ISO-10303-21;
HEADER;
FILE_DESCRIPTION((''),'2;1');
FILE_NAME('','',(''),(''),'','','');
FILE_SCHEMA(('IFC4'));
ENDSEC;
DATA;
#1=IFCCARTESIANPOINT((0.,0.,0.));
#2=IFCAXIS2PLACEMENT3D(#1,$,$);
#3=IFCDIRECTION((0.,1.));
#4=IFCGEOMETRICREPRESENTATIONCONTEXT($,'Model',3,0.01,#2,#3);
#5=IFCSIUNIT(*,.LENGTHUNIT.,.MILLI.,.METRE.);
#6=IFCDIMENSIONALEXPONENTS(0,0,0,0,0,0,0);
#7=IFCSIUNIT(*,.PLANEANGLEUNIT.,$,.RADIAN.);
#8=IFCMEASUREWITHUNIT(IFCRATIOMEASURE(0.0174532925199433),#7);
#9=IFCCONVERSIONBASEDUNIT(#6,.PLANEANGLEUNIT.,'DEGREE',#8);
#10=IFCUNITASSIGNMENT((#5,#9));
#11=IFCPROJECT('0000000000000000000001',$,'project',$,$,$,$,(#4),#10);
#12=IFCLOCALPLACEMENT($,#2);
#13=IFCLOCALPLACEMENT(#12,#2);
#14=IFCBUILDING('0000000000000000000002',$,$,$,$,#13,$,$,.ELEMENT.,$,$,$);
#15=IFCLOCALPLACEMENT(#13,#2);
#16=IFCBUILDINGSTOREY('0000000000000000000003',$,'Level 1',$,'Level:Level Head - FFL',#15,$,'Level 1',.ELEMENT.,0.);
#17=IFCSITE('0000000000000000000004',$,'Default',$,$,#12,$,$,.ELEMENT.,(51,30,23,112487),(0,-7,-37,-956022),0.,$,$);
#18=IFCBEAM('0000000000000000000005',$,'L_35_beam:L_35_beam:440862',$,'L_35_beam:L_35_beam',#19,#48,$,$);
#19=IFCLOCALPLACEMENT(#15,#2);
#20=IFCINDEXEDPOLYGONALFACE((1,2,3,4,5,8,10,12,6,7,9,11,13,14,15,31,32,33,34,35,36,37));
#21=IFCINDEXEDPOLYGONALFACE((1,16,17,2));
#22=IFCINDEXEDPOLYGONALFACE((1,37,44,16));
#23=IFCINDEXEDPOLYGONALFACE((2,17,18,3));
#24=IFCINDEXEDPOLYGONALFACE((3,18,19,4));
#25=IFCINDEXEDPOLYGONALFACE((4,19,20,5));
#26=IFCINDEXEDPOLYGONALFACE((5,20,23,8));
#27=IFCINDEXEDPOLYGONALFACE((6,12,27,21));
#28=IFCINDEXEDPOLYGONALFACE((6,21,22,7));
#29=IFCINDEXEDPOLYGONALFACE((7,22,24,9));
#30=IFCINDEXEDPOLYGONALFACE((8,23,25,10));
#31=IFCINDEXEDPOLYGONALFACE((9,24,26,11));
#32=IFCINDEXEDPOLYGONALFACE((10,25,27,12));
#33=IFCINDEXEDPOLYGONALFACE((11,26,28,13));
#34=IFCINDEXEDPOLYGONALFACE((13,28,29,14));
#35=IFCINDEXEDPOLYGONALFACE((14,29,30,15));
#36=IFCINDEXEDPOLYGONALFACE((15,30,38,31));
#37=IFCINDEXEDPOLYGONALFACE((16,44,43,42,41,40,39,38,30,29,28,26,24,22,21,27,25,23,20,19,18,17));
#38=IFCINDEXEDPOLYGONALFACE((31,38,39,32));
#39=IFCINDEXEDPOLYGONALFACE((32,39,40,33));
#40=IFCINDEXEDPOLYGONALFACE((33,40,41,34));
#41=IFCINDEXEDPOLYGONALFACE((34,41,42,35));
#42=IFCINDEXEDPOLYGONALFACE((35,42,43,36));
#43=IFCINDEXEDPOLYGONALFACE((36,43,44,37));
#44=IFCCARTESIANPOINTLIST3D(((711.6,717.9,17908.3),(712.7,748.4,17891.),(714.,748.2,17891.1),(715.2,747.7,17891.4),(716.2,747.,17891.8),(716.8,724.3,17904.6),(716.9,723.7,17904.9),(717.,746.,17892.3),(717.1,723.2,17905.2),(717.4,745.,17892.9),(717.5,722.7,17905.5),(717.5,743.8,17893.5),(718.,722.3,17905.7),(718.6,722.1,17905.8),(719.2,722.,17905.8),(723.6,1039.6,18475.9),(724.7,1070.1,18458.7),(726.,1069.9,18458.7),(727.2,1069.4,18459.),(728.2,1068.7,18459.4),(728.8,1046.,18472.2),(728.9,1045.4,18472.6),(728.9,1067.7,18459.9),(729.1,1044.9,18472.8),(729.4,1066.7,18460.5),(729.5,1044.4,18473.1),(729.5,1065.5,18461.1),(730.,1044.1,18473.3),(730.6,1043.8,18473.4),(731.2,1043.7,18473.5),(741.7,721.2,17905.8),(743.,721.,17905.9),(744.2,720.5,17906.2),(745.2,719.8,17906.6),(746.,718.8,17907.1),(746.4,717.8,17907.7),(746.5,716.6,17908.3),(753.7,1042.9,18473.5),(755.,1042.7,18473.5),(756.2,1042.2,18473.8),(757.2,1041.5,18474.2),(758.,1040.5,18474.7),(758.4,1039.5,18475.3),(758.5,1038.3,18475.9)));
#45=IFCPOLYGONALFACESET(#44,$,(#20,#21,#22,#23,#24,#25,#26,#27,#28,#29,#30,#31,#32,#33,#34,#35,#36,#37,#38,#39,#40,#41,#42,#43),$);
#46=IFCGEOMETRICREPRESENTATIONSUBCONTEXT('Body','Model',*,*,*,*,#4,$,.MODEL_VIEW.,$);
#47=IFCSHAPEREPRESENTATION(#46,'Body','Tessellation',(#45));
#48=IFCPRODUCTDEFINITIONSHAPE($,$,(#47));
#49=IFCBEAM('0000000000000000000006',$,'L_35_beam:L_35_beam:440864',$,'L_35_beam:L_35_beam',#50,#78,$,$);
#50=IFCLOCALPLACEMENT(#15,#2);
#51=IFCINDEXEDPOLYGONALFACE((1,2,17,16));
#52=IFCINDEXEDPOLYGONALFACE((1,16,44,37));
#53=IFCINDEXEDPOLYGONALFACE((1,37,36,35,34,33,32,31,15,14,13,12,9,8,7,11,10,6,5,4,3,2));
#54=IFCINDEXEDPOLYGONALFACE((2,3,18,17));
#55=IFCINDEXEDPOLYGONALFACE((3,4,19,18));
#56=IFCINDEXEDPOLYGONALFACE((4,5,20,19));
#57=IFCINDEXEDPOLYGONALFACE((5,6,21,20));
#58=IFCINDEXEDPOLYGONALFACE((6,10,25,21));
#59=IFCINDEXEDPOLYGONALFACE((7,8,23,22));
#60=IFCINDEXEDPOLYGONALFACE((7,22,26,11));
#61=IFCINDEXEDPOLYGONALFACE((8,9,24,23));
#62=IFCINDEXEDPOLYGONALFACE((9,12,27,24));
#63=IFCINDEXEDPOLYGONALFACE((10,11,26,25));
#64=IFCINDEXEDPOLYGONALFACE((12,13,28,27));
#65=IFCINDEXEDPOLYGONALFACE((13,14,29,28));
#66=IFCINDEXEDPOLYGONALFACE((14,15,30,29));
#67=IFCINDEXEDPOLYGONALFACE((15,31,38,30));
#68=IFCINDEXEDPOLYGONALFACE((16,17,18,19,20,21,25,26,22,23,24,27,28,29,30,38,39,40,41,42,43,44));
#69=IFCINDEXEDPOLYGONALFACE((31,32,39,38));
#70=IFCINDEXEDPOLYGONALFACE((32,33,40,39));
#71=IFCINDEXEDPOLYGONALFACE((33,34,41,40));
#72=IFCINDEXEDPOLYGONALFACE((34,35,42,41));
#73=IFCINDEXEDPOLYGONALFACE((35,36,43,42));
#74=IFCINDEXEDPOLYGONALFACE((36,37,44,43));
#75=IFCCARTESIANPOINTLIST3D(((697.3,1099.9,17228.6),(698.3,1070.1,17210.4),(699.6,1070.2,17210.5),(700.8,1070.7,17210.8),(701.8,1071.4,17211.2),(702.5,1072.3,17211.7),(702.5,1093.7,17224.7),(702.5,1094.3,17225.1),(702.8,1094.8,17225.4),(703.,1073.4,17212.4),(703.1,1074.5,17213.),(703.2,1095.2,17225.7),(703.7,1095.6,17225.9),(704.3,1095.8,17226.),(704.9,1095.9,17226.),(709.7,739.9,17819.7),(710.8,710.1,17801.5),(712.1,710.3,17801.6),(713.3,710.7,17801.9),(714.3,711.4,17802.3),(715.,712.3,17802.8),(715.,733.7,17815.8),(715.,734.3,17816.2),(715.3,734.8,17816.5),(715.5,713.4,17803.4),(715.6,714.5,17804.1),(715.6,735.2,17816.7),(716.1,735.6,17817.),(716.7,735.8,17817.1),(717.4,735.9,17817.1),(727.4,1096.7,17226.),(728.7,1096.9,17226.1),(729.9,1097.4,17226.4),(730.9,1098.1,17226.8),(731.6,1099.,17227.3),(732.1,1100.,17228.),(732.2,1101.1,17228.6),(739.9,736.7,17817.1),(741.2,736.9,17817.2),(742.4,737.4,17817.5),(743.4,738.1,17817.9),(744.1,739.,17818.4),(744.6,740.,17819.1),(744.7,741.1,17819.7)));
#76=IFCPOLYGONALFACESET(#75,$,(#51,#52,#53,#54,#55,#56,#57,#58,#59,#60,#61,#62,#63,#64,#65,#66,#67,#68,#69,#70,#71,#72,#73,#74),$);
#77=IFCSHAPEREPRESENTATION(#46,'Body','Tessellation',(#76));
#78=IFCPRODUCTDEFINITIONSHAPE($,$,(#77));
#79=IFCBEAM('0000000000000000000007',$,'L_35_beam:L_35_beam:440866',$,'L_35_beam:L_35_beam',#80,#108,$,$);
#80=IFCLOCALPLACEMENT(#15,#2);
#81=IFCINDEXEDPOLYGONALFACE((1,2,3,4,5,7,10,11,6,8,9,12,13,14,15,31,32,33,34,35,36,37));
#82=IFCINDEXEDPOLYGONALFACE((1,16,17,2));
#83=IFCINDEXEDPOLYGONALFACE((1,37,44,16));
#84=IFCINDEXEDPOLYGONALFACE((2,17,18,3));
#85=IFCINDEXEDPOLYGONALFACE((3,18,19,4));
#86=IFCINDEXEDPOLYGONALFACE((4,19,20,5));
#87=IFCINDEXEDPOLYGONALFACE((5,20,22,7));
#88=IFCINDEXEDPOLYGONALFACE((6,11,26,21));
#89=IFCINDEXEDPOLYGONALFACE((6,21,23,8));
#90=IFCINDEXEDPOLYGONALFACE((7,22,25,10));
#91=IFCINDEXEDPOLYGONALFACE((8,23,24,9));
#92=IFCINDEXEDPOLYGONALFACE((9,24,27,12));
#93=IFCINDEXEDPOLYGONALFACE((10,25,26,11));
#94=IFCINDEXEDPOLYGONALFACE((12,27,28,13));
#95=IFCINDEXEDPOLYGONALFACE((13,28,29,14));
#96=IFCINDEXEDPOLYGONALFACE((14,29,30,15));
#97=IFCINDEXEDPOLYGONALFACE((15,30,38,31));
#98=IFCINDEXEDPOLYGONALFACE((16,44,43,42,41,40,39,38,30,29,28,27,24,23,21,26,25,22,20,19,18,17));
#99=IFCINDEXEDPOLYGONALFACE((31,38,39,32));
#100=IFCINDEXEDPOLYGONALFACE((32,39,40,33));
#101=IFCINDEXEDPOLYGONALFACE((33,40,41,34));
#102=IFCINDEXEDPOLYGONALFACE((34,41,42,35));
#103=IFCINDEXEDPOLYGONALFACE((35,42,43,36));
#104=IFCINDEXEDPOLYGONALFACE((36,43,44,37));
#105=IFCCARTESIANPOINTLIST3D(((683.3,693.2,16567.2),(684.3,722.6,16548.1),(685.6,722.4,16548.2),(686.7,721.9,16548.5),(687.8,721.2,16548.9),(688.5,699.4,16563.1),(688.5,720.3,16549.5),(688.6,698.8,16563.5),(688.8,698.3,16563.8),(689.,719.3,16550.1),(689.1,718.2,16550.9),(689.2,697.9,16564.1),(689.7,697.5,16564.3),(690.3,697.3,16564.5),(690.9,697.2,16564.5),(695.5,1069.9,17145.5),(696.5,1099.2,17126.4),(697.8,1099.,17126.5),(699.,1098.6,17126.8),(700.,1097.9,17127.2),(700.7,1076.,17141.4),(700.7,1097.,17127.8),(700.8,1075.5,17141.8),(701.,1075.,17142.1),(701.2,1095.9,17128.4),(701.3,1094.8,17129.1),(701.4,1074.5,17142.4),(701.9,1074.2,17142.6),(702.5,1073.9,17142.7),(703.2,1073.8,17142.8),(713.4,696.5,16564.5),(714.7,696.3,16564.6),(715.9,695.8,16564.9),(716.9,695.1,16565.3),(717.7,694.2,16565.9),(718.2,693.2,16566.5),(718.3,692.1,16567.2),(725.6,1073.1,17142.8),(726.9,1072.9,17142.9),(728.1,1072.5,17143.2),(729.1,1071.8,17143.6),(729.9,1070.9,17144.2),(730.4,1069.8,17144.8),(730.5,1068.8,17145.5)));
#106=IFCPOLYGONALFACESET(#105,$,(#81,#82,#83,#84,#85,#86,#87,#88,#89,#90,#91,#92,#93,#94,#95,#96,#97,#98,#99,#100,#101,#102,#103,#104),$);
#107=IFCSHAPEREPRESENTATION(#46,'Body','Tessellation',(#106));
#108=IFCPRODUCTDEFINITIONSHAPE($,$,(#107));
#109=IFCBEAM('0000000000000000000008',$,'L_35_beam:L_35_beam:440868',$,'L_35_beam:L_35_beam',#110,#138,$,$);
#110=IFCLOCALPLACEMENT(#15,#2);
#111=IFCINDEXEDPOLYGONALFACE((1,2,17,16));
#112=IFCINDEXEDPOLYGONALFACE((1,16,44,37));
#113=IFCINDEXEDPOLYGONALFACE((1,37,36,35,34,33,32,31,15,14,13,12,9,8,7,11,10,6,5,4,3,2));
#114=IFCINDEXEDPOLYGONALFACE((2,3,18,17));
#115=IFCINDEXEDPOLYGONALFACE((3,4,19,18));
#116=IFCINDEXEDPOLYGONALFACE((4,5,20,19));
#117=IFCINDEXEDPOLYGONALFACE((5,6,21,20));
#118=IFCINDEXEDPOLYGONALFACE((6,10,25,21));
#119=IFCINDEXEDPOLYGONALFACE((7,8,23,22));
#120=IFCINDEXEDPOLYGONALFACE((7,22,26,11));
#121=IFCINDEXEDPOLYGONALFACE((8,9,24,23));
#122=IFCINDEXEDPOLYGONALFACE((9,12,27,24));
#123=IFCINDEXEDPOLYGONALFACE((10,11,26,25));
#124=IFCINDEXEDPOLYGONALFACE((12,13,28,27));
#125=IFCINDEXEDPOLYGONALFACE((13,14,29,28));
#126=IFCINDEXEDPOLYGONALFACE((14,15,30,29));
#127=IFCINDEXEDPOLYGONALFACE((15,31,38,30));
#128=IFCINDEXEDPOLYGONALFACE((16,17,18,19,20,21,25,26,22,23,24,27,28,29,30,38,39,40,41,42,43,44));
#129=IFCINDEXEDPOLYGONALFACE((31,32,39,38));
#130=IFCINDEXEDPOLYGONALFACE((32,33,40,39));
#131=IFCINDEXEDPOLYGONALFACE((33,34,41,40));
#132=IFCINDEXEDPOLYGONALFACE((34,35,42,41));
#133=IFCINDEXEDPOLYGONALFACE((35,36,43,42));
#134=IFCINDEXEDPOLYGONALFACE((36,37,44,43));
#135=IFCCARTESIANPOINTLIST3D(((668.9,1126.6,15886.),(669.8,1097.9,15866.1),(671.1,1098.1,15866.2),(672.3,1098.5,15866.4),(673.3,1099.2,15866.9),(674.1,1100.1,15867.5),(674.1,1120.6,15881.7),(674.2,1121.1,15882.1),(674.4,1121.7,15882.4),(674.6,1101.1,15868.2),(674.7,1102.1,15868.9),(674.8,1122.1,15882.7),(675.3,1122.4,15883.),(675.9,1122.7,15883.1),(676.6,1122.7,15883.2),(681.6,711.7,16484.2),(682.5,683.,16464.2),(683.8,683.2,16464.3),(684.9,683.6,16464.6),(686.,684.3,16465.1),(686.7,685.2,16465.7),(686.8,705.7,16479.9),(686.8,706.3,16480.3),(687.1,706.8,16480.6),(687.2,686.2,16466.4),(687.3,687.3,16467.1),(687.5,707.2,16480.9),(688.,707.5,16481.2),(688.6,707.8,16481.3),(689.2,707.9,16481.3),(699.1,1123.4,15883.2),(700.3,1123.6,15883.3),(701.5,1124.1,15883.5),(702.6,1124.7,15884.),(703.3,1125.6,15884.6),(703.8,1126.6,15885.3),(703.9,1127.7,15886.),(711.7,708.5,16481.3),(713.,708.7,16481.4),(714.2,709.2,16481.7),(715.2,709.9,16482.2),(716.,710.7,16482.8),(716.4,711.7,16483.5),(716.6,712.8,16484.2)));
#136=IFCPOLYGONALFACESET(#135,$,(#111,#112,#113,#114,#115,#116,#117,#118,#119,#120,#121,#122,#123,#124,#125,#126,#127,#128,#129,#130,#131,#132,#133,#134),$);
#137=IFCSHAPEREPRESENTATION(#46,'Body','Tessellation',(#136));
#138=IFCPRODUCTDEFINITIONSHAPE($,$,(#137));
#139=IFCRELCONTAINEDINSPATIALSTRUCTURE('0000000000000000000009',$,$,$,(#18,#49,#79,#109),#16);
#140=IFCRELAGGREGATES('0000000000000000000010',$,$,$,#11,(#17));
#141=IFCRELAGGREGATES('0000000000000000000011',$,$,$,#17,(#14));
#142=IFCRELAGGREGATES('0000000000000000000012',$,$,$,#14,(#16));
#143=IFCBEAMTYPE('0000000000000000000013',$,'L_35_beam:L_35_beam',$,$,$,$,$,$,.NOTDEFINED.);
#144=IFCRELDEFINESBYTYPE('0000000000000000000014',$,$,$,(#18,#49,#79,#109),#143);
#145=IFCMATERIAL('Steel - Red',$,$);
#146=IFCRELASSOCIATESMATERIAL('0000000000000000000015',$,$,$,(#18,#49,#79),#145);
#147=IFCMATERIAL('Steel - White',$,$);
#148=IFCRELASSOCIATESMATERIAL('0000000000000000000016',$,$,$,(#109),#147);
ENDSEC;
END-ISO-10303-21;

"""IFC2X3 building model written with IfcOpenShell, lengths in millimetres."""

from ifc_helpers import new_model, entity, si_unit, converted_unit, direction, frame, frame_2d, origin, place, context, subcontext, project, spatial, polyline, circle_curve, parameter, trimmed, segment, composite_curve, outline, extrude, material, type_object, element, save


model = new_model("IFC2X3")

# Units and contexts
model_context = context("Model", 3, precision=0.01, world=origin(), true_north=direction((0.0, 1.0)))
body_context = subcontext(model_context, "Body", "Model", "MODEL_VIEW")
ifc_project = project(units=[si_unit("LENGTHUNIT", "METRE", prefix="MILLI"), converted_unit("PLANEANGLEUNIT", "DEGREE", entity("IfcRatioMeasure", 0.0174532925199433), si_unit("PLANEANGLEUNIT", "RADIAN"), dimensions=[0, 0, 0, 0, 0, 0, 0])], contexts=[model_context])

# Site, building, storey
site_placement = place(None, origin())
site = spatial("IfcSite", under=ifc_project, at=site_placement, Name="Default", CompositionType="ELEMENT", RefLatitude=(51, 30, 23, 112487), RefLongitude=(0, -7, -37, -956022), RefElevation=0.0)
building_placement = place(site_placement, origin())
building = spatial("IfcBuilding", under=site, at=building_placement, CompositionType="ELEMENT")
storey_placement = place(building_placement, origin())
storey = spatial("IfcBuildingStorey", under=building, at=storey_placement, Name="Level 1", ObjectType="Level:Level Head - FFL", LongName="Level 1", CompositionType="ELEMENT", Elevation=0.0)

# Beams
ifc_material_1 = material(Name="Steel - Red")
ifc_material_2 = material(Name="Steel - White")
beam_type_1 = type_object("IfcBeamType", Name="L_35_beam:L_35_beam", PredefinedType="NOTDEFINED")
beam_1_placement = place(storey_placement, frame((703.0, 703.1, 17846.1), z_axis=(0.999831, -0.009062, -0.01599), x_axis=(0.018379, 0.492997, 0.869837)))
element("IfcBeam", 1, at=beam_1_placement, inside=storey, type_object=beam_type_1, material=ifc_material_1, Name="L_35_beam:L_35_beam:440862", ObjectType="L_35_beam:L_35_beam", context=body_context, shape_type="SweptSolid", body=[
    extrude(outline(composite_curve([segment(polyline([(-11.8, -11.8), (23.2, -11.8)]), True, "CONTINUOUS"), segment(trimmed(circle_curve(frame_2d((18.2, -11.8), x_axis=(1.0, 0.0)), 5.0), [parameter(0.0)], [parameter(90.0)], True, "PARAMETER"), True, "CONTINUOUS"), segment(polyline([(18.2, -6.8), (-4.3, -6.8)]), True, "CONTINUOUS"), segment(trimmed(circle_curve(frame_2d((-4.3, -4.3), x_axis=(0.0, -1.0)), 2.5), [parameter(270.0)], [parameter(0.0)], True, "PARAMETER"), False, "CONTINUOUS"), segment(polyline([(-6.8, -4.3), (-6.8, 18.2)]), True, "CONTINUOUS"), segment(trimmed(circle_curve(frame_2d((-11.8, 18.2), x_axis=(1.0, 0.0)), 5.0), [parameter(0.0)], [parameter(90.0)], True, "PARAMETER"), True, "CONTINUOUS"), segment(polyline([(-11.8, 23.2), (-11.8, -11.8)]), True, "CONTINUOUS")], self_intersect=False)), frame((61.6, 6.4, 19.6), z_axis=(1.0, 0.0, 0.0), x_axis=(0.0, 0.032411, 0.999475)), (0.0, 0.0, 1.0), 652.6),
])
beam_2_placement = place(storey_placement, frame((703.0, 703.1, 17846.1), z_axis=(0.999837, 0.009385, -0.01541), x_axis=(-0.018043, 0.520075, -0.85393)))
element("IfcBeam", 2, at=beam_2_placement, inside=storey, type_object=beam_type_1, material=ifc_material_1, Name="L_35_beam:L_35_beam:440864", ObjectType="L_35_beam:L_35_beam", context=body_context, shape_type="SweptSolid", body=[
    extrude(outline(composite_curve([segment(polyline([(-11.8, -11.8), (23.2, -11.8)]), True, "CONTINUOUS"), segment(trimmed(circle_curve(frame_2d((18.2, -11.8), x_axis=(1.0, 0.0)), 5.0), [parameter(0.0)], [parameter(90.0)], True, "PARAMETER"), True, "CONTINUOUS"), segment(polyline([(18.2, -6.8), (-4.3, -6.8)]), True, "CONTINUOUS"), segment(trimmed(circle_curve(frame_2d((-4.3, -4.3), x_axis=(0.0, -1.0)), 2.5), [parameter(270.0)], [parameter(0.0)], True, "PARAMETER"), False, "CONTINUOUS"), segment(polyline([(-6.8, -4.3), (-6.8, 18.2)]), True, "CONTINUOUS"), segment(trimmed(circle_curve(frame_2d((-11.8, 18.2), x_axis=(1.0, 0.0)), 5.0), [parameter(0.0)], [parameter(90.0)], True, "PARAMETER"), True, "CONTINUOUS"), segment(polyline([(-11.8, 23.2), (-11.8, -11.8)]), True, "CONTINUOUS")], self_intersect=False)), frame((41.6, 6.3, 19.6), z_axis=(1.0, 0.0, 0.0), x_axis=(0.0, 0.029613, 0.999561)), (0.0, 0.0, 1.0), 692.2),
])
beam_3_placement = place(storey_placement, frame((674.7, 674.8, 16506.4), z_axis=(0.999843, -0.009661, -0.014834), x_axis=(0.017703, 0.545672, 0.837812)))
element("IfcBeam", 3, at=beam_3_placement, inside=storey, type_object=beam_type_1, material=ifc_material_1, Name="L_35_beam:L_35_beam:440866", ObjectType="L_35_beam:L_35_beam", context=body_context, shape_type="SweptSolid", body=[
    extrude(outline(composite_curve([segment(polyline([(-11.8, -11.8), (23.2, -11.8)]), True, "CONTINUOUS"), segment(trimmed(circle_curve(frame_2d((18.2, -11.8), x_axis=(1.0, 0.0)), 5.0), [parameter(0.0)], [parameter(90.0)], True, "PARAMETER"), True, "CONTINUOUS"), segment(polyline([(18.2, -6.8), (-4.3, -6.8)]), True, "CONTINUOUS"), segment(trimmed(circle_curve(frame_2d((-4.3, -4.3), x_axis=(0.0, -1.0)), 2.5), [parameter(270.0)], [parameter(0.0)], True, "PARAMETER"), False, "CONTINUOUS"), segment(polyline([(-6.8, -4.3), (-6.8, 18.2)]), True, "CONTINUOUS"), segment(trimmed(circle_curve(frame_2d((-11.8, 18.2), x_axis=(1.0, 0.0)), 5.0), [parameter(0.0)], [parameter(90.0)], True, "PARAMETER"), True, "CONTINUOUS"), segment(polyline([(-11.8, 23.2), (-11.8, -11.8)]), True, "CONTINUOUS")], self_intersect=False)), frame((61.2, 6.2, 19.6), z_axis=(1.0, 0.0, 0.0), x_axis=(0.0, 0.02717, 0.999631)), (0.0, 0.0, 1.0), 690.2),
])
beam_4_placement = place(storey_placement, frame((674.7, 674.8, 16506.4), z_axis=(0.999849, 0.009893, -0.014264), x_axis=(-0.01736, 0.569827, -0.821581)))
element("IfcBeam", 4, at=beam_4_placement, inside=storey, type_object=beam_type_1, material=ifc_material_2, Name="L_35_beam:L_35_beam:440868", ObjectType="L_35_beam:L_35_beam", context=body_context, shape_type="SweptSolid", body=[
    extrude(outline(composite_curve([segment(polyline([(-11.8, -11.8), (23.2, -11.8)]), True, "CONTINUOUS"), segment(trimmed(circle_curve(frame_2d((18.2, -11.8), x_axis=(1.0, 0.0)), 5.0), [parameter(0.0)], [parameter(90.0)], True, "PARAMETER"), True, "CONTINUOUS"), segment(polyline([(18.2, -6.8), (-4.3, -6.8)]), True, "CONTINUOUS"), segment(trimmed(circle_curve(frame_2d((-4.3, -4.3), x_axis=(0.0, -1.0)), 2.5), [parameter(270.0)], [parameter(0.0)], True, "PARAMETER"), False, "CONTINUOUS"), segment(polyline([(-6.8, -4.3), (-6.8, 18.2)]), True, "CONTINUOUS"), segment(trimmed(circle_curve(frame_2d((-11.8, 18.2), x_axis=(1.0, 0.0)), 5.0), [parameter(0.0)], [parameter(90.0)], True, "PARAMETER"), True, "CONTINUOUS"), segment(polyline([(-11.8, 23.2), (-11.8, -11.8)]), True, "CONTINUOUS")], self_intersect=False)), frame((39.2, 6.2, 19.6), z_axis=(1.0, 0.0, 0.0), x_axis=(0.0, 0.025021, 0.999687)), (0.0, 0.0, 1.0), 728.1),
])

save(model, "model.ifc")
